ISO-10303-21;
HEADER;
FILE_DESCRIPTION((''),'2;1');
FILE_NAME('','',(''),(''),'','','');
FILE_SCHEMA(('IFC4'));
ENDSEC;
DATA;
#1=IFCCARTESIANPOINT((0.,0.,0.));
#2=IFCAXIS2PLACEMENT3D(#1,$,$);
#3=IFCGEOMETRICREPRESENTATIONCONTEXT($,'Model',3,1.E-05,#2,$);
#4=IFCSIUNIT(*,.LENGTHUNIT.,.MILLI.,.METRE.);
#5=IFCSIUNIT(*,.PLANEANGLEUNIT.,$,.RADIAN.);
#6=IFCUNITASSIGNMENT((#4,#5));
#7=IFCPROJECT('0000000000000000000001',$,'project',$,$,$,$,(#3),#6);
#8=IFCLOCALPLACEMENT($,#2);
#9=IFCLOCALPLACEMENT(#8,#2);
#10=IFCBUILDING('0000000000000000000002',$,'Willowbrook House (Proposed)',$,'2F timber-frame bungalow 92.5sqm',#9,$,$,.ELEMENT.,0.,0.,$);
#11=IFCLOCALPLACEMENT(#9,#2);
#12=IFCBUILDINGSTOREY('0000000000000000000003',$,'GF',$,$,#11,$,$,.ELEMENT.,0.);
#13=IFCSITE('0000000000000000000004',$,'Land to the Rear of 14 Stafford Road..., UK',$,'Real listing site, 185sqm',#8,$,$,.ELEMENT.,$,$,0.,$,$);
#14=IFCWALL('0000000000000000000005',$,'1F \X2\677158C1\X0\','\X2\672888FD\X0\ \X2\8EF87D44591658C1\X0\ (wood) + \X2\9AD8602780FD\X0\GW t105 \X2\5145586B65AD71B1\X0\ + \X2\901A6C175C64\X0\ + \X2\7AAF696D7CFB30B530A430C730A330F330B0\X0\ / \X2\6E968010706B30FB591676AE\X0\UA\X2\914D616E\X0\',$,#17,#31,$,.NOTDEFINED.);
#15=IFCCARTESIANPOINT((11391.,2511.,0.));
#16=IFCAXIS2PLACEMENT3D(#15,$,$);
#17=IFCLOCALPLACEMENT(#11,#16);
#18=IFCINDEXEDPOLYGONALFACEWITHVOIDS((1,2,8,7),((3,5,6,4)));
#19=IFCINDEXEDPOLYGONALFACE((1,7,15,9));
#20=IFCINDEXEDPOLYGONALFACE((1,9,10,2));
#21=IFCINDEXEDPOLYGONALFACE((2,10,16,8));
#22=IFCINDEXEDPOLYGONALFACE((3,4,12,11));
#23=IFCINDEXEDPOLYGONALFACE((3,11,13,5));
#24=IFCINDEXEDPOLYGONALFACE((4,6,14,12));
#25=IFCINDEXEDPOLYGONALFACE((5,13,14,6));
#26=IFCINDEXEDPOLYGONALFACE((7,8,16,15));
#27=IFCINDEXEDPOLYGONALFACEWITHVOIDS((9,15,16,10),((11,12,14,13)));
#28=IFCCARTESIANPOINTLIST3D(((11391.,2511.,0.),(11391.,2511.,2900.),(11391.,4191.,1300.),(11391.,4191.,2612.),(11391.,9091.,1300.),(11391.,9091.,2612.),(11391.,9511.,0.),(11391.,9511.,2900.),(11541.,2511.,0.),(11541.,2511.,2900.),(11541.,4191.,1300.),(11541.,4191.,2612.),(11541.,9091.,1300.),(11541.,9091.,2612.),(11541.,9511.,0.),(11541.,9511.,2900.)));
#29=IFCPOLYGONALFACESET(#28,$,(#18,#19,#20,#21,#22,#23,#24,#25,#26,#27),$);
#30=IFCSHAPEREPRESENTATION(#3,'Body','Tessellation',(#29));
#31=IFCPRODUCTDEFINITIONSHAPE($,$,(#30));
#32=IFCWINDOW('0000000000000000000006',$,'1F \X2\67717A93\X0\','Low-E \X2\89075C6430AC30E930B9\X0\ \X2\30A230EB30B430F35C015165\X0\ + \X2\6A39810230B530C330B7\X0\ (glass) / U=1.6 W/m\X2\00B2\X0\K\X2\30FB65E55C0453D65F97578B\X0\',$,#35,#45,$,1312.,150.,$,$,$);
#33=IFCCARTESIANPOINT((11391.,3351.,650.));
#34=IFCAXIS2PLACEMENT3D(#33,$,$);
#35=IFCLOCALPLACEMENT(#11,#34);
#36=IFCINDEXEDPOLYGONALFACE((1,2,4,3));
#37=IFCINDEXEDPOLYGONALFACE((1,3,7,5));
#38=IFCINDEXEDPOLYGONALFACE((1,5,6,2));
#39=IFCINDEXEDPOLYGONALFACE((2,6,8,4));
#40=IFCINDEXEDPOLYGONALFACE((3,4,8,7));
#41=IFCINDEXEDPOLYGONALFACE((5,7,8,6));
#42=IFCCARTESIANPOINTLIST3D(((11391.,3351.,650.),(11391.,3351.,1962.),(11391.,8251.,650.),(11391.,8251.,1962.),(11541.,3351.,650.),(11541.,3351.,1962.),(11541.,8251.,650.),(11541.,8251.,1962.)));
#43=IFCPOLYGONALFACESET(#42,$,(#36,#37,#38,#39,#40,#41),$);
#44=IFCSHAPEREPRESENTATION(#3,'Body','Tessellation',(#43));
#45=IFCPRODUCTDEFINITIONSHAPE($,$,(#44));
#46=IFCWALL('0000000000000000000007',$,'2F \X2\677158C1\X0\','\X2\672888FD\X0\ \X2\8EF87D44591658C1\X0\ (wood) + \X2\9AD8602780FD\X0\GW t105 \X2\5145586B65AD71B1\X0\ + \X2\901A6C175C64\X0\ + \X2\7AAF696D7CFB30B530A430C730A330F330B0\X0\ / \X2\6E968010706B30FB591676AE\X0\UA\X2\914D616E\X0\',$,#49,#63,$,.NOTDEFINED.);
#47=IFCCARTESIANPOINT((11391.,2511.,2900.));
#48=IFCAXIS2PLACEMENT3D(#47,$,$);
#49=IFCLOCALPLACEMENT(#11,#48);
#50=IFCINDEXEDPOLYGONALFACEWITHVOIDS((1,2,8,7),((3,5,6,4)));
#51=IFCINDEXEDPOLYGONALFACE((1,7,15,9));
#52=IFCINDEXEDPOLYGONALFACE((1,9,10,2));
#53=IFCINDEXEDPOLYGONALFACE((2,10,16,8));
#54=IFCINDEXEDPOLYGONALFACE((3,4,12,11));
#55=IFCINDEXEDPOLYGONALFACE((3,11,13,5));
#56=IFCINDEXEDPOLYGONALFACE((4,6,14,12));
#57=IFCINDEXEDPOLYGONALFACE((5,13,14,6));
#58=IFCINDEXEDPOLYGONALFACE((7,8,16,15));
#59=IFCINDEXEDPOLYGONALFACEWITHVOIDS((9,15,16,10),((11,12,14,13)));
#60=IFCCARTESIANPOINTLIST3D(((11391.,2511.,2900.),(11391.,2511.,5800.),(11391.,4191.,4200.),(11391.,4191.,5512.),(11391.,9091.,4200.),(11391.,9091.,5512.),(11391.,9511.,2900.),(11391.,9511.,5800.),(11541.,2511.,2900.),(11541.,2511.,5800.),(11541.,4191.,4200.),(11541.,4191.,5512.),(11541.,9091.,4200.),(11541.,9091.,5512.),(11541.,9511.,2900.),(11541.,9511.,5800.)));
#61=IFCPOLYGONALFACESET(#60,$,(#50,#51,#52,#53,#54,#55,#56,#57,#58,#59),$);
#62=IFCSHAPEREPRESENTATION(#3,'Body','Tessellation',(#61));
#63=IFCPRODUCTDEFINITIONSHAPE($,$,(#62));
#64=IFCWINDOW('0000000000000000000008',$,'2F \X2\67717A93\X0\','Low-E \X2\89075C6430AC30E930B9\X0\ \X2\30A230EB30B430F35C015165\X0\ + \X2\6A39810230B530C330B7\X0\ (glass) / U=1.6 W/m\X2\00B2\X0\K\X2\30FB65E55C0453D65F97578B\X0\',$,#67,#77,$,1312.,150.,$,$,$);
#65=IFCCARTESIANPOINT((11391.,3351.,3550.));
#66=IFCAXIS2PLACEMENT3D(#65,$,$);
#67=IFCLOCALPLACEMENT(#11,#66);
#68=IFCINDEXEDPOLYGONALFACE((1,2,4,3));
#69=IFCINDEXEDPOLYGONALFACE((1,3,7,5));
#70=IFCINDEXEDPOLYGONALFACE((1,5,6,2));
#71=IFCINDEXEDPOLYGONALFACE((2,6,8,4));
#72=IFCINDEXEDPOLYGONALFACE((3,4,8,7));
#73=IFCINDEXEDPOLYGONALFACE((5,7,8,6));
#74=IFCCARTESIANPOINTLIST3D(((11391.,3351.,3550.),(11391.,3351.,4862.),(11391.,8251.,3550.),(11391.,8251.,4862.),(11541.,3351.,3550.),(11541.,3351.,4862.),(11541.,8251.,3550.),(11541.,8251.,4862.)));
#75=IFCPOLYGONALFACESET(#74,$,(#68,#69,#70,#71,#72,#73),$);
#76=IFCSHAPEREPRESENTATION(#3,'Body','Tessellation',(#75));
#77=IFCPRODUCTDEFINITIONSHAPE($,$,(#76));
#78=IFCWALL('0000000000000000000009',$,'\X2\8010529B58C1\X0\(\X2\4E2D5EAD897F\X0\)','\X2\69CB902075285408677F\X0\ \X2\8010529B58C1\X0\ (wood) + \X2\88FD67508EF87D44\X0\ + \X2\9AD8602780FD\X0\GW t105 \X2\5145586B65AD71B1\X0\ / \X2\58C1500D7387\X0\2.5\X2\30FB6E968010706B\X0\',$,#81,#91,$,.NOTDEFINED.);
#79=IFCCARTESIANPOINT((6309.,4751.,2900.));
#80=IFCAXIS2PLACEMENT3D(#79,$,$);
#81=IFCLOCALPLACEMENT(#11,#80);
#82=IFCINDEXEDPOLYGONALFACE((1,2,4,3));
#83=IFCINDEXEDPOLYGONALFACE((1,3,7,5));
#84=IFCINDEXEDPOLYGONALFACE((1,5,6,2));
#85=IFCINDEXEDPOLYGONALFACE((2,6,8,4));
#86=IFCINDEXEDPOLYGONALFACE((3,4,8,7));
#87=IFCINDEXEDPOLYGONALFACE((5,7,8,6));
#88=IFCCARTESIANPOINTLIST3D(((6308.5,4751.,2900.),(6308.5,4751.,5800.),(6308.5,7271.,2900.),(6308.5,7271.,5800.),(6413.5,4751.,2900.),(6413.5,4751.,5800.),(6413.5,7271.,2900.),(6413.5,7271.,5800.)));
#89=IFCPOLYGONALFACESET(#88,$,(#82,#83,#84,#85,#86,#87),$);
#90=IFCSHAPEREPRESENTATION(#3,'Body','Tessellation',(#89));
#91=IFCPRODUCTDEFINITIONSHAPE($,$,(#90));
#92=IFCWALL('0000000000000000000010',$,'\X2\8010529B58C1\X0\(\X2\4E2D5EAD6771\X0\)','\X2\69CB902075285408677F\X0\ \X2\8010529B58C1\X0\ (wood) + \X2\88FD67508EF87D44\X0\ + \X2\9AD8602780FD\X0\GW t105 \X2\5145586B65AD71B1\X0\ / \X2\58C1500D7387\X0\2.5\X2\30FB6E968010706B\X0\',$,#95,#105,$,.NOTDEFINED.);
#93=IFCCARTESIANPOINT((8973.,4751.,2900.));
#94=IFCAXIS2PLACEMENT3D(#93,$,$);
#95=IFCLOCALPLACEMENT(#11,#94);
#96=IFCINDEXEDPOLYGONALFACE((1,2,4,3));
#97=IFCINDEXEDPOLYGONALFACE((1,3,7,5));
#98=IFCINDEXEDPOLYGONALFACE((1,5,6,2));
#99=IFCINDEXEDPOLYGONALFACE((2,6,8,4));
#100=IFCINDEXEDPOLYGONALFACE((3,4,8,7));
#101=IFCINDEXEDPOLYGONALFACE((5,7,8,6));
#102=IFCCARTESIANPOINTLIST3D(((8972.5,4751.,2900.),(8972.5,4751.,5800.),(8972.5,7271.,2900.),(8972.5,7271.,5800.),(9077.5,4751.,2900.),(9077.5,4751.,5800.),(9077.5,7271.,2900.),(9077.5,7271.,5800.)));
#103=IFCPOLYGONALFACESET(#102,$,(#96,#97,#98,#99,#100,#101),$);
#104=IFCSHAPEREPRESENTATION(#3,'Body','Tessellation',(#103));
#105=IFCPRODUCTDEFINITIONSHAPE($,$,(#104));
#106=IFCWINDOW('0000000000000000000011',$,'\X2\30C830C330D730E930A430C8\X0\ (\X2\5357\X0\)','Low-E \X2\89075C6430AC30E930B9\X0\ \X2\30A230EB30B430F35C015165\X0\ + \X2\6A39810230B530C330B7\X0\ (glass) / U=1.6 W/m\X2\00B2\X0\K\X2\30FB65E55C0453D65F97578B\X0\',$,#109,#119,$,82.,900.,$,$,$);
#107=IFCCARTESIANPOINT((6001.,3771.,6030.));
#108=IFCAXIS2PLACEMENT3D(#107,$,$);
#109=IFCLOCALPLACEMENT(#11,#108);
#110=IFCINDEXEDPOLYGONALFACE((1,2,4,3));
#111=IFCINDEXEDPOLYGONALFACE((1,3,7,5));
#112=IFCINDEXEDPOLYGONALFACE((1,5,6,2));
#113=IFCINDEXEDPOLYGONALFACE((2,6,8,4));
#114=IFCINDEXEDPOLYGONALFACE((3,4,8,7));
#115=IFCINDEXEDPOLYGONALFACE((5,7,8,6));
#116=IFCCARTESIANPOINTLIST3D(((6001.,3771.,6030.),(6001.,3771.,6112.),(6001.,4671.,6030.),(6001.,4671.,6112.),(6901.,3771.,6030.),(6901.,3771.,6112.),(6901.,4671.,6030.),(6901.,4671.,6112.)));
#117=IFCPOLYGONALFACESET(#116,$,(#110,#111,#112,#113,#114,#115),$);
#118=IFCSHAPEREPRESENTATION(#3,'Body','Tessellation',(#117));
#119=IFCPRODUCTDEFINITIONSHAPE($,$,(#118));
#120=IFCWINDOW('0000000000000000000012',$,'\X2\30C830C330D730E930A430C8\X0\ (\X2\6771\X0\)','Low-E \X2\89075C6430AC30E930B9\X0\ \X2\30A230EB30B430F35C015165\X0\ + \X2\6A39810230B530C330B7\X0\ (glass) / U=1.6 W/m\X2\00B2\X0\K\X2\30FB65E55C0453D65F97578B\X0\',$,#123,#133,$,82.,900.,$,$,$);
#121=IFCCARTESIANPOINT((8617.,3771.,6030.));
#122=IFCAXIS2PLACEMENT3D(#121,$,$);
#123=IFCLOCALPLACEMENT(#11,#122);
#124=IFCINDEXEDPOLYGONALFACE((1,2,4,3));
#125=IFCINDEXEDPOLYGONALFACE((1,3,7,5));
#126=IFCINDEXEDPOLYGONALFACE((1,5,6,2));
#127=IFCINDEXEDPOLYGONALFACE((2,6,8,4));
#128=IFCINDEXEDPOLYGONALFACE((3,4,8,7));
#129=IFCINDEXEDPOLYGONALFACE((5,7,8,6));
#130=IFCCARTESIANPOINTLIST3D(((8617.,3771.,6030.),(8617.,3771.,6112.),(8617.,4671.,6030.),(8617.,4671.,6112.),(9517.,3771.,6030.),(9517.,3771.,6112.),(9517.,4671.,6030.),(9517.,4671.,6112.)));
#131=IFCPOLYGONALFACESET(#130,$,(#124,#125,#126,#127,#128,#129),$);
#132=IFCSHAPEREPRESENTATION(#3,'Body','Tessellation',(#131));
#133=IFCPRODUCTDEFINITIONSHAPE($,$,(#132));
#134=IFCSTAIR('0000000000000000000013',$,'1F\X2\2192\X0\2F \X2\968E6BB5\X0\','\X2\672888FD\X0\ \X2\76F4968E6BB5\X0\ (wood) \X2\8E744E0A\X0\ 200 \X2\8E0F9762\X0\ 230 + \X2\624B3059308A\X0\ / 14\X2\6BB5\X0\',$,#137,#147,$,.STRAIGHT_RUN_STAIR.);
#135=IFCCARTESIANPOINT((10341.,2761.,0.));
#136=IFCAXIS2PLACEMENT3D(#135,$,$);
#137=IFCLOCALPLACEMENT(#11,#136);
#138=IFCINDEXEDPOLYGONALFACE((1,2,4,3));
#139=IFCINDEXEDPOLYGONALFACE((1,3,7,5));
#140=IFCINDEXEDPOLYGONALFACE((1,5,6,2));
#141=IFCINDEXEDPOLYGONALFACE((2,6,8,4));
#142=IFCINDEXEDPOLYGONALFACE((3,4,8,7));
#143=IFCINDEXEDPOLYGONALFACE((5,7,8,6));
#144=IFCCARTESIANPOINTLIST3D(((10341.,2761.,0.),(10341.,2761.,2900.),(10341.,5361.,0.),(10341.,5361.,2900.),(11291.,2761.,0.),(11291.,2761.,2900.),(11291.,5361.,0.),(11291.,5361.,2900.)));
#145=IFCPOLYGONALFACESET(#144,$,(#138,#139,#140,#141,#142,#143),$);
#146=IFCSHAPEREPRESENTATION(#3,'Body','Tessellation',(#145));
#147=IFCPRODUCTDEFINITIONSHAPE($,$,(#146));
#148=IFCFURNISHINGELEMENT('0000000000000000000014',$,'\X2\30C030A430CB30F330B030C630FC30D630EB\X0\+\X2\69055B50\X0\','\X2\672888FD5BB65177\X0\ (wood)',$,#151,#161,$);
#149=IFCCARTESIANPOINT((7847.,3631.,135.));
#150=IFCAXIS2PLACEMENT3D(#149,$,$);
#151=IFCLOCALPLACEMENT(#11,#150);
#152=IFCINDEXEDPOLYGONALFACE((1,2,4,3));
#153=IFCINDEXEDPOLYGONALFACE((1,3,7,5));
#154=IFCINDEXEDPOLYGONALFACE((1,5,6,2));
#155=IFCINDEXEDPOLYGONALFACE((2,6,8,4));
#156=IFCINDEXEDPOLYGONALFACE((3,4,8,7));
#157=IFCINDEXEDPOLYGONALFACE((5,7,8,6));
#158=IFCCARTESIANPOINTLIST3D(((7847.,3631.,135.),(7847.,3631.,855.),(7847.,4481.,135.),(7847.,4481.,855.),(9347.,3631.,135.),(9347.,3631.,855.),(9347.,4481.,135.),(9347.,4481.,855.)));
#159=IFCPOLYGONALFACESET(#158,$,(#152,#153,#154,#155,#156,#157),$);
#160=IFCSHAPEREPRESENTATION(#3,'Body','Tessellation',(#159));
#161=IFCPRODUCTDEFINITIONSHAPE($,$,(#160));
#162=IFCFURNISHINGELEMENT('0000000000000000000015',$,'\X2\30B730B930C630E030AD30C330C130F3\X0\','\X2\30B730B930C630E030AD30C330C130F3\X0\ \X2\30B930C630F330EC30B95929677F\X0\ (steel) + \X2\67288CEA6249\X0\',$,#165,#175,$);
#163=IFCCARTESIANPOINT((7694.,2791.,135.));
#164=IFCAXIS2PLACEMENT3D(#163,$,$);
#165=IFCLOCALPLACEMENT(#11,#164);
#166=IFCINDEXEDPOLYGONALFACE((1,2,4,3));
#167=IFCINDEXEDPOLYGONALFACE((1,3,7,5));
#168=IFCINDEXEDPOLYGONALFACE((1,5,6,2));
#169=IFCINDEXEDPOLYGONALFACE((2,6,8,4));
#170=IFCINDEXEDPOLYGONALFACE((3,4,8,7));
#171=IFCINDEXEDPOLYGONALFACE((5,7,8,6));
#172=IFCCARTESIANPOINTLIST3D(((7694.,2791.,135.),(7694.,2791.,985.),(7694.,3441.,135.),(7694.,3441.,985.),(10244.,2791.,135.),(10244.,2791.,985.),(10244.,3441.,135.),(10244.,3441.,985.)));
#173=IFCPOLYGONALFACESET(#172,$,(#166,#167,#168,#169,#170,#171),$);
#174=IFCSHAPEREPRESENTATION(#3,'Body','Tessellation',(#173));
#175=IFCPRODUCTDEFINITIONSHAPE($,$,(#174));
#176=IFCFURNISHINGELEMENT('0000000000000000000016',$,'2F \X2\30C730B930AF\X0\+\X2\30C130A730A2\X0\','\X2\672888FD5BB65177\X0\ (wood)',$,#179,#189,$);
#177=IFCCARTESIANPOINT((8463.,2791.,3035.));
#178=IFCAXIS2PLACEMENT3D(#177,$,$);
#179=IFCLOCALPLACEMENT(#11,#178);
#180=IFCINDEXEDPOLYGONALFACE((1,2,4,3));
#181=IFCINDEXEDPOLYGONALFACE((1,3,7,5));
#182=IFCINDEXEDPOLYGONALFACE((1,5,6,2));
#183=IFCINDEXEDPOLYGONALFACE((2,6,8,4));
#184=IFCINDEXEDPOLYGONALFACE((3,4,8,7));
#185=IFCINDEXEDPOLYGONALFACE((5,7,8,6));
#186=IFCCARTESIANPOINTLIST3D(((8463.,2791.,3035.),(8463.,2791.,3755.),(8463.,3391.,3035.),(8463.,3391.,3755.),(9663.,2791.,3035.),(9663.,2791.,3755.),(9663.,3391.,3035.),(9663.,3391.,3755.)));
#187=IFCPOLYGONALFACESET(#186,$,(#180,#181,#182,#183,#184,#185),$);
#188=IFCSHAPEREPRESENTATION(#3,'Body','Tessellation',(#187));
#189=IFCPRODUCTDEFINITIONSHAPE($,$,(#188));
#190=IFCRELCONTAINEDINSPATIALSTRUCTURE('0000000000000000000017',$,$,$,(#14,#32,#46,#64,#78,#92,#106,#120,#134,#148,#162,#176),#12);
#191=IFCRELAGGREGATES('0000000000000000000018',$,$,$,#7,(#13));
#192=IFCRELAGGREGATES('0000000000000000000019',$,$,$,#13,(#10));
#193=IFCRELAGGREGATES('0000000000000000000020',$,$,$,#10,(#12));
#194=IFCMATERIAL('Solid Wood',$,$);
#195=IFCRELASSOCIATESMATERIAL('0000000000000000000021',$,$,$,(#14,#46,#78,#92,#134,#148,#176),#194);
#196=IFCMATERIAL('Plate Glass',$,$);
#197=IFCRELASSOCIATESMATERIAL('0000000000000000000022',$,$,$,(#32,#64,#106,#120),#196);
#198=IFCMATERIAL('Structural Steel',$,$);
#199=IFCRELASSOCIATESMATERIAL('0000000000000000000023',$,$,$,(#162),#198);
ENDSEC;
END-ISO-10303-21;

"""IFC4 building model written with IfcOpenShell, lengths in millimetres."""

from ifc_helpers import new_model, si_unit, frame, frame_2d, origin, place, context, project, spatial, rectangle, extrude, material, element, fill, save


model = new_model("IFC4")

# Units and contexts
model_context = context("Model", 3, precision=1e-05, world=origin())
ifc_project = project(units=[si_unit("LENGTHUNIT", "METRE", prefix="MILLI"), si_unit("PLANEANGLEUNIT", "RADIAN")], contexts=[model_context])

# Site, building, storey
site_placement = place(None, origin())
site = spatial("IfcSite", under=ifc_project, at=site_placement, Name="Land to the Rear of 14 Stafford Road..., UK", ObjectType="Real listing site, 185sqm", CompositionType="ELEMENT", RefElevation=0.0)
building_placement = place(site_placement, origin())
building = spatial("IfcBuilding", under=site, at=building_placement, Name="Willowbrook House (Proposed)", ObjectType="2F timber-frame bungalow 92.5sqm", CompositionType="ELEMENT", ElevationOfRefHeight=0.0, ElevationOfTerrain=0.0)
storey_placement = place(building_placement, origin())
storey = spatial("IfcBuildingStorey", under=building, at=storey_placement, Name="GF", CompositionType="ELEMENT", Elevation=0.0)

# Shared definitions
ifc_material_1 = material(Name="Solid Wood")

# Wall, opening, window
wall_1_placement = place(storey_placement, frame((11391.0, 2511.0, 0.0)))
wall_1 = element("IfcWall", 1, at=wall_1_placement, inside=storey, material=ifc_material_1, Name="1F 東壁", Description="木製 軸組外壁 (wood) + 高性能GW t105 充填断熱 + 通気層 + 窯業系サイディング / 準耐火・外皮UA配慮", PredefinedType="NOTDEFINED", context=model_context, shape_type="SweptSolid", body=[
    extrude(rectangle(XDim=150.0, YDim=7000.0, at=frame_2d((75.0, 3500.0))), frame((11391.0, 2511.0, 0.0)), (0.0, 0.0, 1.0), 2900.0),
])
opening_1_placement = place(storey_placement, frame((11391.0, 3351.0, 650.0)))
opening_1 = element("IfcOpeningElement", 2, at=opening_1_placement, cuts=wall_1, PredefinedType="NOTDEFINED", context=model_context, shape_type="SweptSolid", body=[
    extrude(rectangle(XDim=150.0, YDim=4900.0, at=frame_2d((75.0, 2450.0))), frame((11391.0, 3351.0, 650.0)), (0.0, 0.0, 1.0), 1312.0),
])
ifc_material_2 = material(Name="Plate Glass")
window_1_placement = place(storey_placement, frame((11391.0, 3351.0, 650.0)))
window_1 = element("IfcWindow", 3, at=window_1_placement, inside=storey, material=ifc_material_2, Name="1F 東窓", Description="Low-E 複層ガラス アルゴン封入 + 樹脂サッシ (glass) / U=1.6 W/m²K・日射取得型", OverallHeight=1312.0, OverallWidth=150.0, context=model_context, shape_type="SweptSolid", body=[
    extrude(rectangle(XDim=150.0, YDim=4900.0, at=frame_2d((75.0, 2450.0))), frame((11391.0, 3351.0, 650.0)), (0.0, 0.0, 1.0), 1312.0),
])
fill(opening_1, window_1)

# Wall, opening, window
wall_2_placement = place(storey_placement, frame((11391.0, 2511.0, 2900.0)))
wall_2 = element("IfcWall", 4, at=wall_2_placement, inside=storey, material=ifc_material_1, Name="2F 東壁", Description="木製 軸組外壁 (wood) + 高性能GW t105 充填断熱 + 通気層 + 窯業系サイディング / 準耐火・外皮UA配慮", PredefinedType="NOTDEFINED", context=model_context, shape_type="SweptSolid", body=[
    extrude(rectangle(XDim=150.0, YDim=7000.0, at=frame_2d((75.0, 3500.0))), frame((11391.0, 2511.0, 2900.0)), (0.0, 0.0, 1.0), 2900.0),
])
opening_2_placement = place(storey_placement, frame((11391.0, 3351.0, 3550.0)))
opening_2 = element("IfcOpeningElement", 5, at=opening_2_placement, cuts=wall_2, PredefinedType="NOTDEFINED", context=model_context, shape_type="SweptSolid", body=[
    extrude(rectangle(XDim=150.0, YDim=4900.0, at=frame_2d((75.0, 2450.0))), frame((11391.0, 3351.0, 3550.0)), (0.0, 0.0, 1.0), 1312.0),
])
window_2_placement = place(storey_placement, frame((11391.0, 3351.0, 3550.0)))
window_2 = element("IfcWindow", 6, at=window_2_placement, inside=storey, material=ifc_material_2, Name="2F 東窓", Description="Low-E 複層ガラス アルゴン封入 + 樹脂サッシ (glass) / U=1.6 W/m²K・日射取得型", OverallHeight=1312.0, OverallWidth=150.0, context=model_context, shape_type="SweptSolid", body=[
    extrude(rectangle(XDim=150.0, YDim=4900.0, at=frame_2d((75.0, 2450.0))), frame((11391.0, 3351.0, 3550.0)), (0.0, 0.0, 1.0), 1312.0),
])
fill(opening_2, window_2)

# Walls
wall_3_placement = place(storey_placement, frame((6309.0, 4751.0, 2900.0)))
element("IfcWall", 7, at=wall_3_placement, inside=storey, material=ifc_material_1, Name="耐力壁(中庭西)", Description="構造用合板 耐力壁 (wood) + 製材軸組 + 高性能GW t105 充填断熱 / 壁倍率2.5・準耐火", PredefinedType="NOTDEFINED", context=model_context, shape_type="SweptSolid", body=[
    extrude(rectangle(XDim=105.0, YDim=2520.0, at=frame_2d((52.0, 1260.0))), frame((6309.0, 4751.0, 2900.0)), (0.0, 0.0, 1.0), 2900.0),
])
wall_4_placement = place(storey_placement, frame((8973.0, 4751.0, 2900.0)))
element("IfcWall", 8, at=wall_4_placement, inside=storey, material=ifc_material_1, Name="耐力壁(中庭東)", Description="構造用合板 耐力壁 (wood) + 製材軸組 + 高性能GW t105 充填断熱 / 壁倍率2.5・準耐火", PredefinedType="NOTDEFINED", context=model_context, shape_type="SweptSolid", body=[
    extrude(rectangle(XDim=105.0, YDim=2520.0, at=frame_2d((52.0, 1260.0))), frame((8973.0, 4751.0, 2900.0)), (0.0, 0.0, 1.0), 2900.0),
])

# Windows
window_3_placement = place(storey_placement, frame((6001.0, 3771.0, 6030.0)))
element("IfcWindow", 9, at=window_3_placement, inside=storey, material=ifc_material_2, Name="トップライト (南)", Description="Low-E 複層ガラス アルゴン封入 + 樹脂サッシ (glass) / U=1.6 W/m²K・日射取得型", OverallHeight=82.0, OverallWidth=900.0, context=model_context, shape_type="SweptSolid", body=[
    extrude(rectangle(XDim=900.0, YDim=900.0, at=frame_2d((450.0, 450.0))), frame((6001.0, 3771.0, 6030.0)), (0.0, 0.0, 1.0), 82.0),
])
window_4_placement = place(storey_placement, frame((8617.0, 3771.0, 6030.0)))
element("IfcWindow", 10, at=window_4_placement, inside=storey, material=ifc_material_2, Name="トップライト (東)", Description="Low-E 複層ガラス アルゴン封入 + 樹脂サッシ (glass) / U=1.6 W/m²K・日射取得型", OverallHeight=82.0, OverallWidth=900.0, context=model_context, shape_type="SweptSolid", body=[
    extrude(rectangle(XDim=900.0, YDim=900.0, at=frame_2d((450.0, 450.0))), frame((8617.0, 3771.0, 6030.0)), (0.0, 0.0, 1.0), 82.0),
])

# Stair
stair_placement = place(storey_placement, frame((10341.0, 2761.0, 0.0)))
element("IfcStair", 11, at=stair_placement, inside=storey, material=ifc_material_1, Name="1F→2F 階段", Description="木製 直階段 (wood) 蹴上 200 踏面 230 + 手すり / 14段", PredefinedType="STRAIGHT_RUN_STAIR", context=model_context, shape_type="SweptSolid", body=[
    extrude(rectangle(XDim=950.0, YDim=2600.0, at=frame_2d((475.0, 1300.0))), frame((10341.0, 2761.0, 0.0)), (0.0, 0.0, 1.0), 2900.0),
])

# Furnishing elements
furnishing_1_placement = place(storey_placement, frame((7847.0, 3631.0, 135.0)))
element("IfcFurnishingElement", 12, at=furnishing_1_placement, inside=storey, material=ifc_material_1, Name="ダイニングテーブル+椅子", Description="木製家具 (wood)", context=model_context, shape_type="SweptSolid", body=[
    extrude(rectangle(XDim=1500.0, YDim=850.0, at=frame_2d((750.0, 425.0))), frame((7847.0, 3631.0, 135.0)), (0.0, 0.0, 1.0), 720.0),
])
ifc_material_3 = material(Name="Structural Steel")
furnishing_2_placement = place(storey_placement, frame((7694.0, 2791.0, 135.0)))
element("IfcFurnishingElement", 13, at=furnishing_2_placement, inside=storey, material=ifc_material_3, Name="システムキッチン", Description="システムキッチン ステンレス天板 (steel) + 木質扉", context=model_context, shape_type="SweptSolid", body=[
    extrude(rectangle(XDim=2550.0, YDim=650.0, at=frame_2d((1275.0, 325.0))), frame((7694.0, 2791.0, 135.0)), (0.0, 0.0, 1.0), 850.0),
])
furnishing_3_placement = place(storey_placement, frame((8463.0, 2791.0, 3035.0)))
element("IfcFurnishingElement", 14, at=furnishing_3_placement, inside=storey, material=ifc_material_1, Name="2F デスク+チェア", Description="木製家具 (wood)", context=model_context, shape_type="SweptSolid", body=[
    extrude(rectangle(XDim=1200.0, YDim=600.0, at=frame_2d((600.0, 300.0))), frame((8463.0, 2791.0, 3035.0)), (0.0, 0.0, 1.0), 720.0),
])

save(model, "model.ifc")
